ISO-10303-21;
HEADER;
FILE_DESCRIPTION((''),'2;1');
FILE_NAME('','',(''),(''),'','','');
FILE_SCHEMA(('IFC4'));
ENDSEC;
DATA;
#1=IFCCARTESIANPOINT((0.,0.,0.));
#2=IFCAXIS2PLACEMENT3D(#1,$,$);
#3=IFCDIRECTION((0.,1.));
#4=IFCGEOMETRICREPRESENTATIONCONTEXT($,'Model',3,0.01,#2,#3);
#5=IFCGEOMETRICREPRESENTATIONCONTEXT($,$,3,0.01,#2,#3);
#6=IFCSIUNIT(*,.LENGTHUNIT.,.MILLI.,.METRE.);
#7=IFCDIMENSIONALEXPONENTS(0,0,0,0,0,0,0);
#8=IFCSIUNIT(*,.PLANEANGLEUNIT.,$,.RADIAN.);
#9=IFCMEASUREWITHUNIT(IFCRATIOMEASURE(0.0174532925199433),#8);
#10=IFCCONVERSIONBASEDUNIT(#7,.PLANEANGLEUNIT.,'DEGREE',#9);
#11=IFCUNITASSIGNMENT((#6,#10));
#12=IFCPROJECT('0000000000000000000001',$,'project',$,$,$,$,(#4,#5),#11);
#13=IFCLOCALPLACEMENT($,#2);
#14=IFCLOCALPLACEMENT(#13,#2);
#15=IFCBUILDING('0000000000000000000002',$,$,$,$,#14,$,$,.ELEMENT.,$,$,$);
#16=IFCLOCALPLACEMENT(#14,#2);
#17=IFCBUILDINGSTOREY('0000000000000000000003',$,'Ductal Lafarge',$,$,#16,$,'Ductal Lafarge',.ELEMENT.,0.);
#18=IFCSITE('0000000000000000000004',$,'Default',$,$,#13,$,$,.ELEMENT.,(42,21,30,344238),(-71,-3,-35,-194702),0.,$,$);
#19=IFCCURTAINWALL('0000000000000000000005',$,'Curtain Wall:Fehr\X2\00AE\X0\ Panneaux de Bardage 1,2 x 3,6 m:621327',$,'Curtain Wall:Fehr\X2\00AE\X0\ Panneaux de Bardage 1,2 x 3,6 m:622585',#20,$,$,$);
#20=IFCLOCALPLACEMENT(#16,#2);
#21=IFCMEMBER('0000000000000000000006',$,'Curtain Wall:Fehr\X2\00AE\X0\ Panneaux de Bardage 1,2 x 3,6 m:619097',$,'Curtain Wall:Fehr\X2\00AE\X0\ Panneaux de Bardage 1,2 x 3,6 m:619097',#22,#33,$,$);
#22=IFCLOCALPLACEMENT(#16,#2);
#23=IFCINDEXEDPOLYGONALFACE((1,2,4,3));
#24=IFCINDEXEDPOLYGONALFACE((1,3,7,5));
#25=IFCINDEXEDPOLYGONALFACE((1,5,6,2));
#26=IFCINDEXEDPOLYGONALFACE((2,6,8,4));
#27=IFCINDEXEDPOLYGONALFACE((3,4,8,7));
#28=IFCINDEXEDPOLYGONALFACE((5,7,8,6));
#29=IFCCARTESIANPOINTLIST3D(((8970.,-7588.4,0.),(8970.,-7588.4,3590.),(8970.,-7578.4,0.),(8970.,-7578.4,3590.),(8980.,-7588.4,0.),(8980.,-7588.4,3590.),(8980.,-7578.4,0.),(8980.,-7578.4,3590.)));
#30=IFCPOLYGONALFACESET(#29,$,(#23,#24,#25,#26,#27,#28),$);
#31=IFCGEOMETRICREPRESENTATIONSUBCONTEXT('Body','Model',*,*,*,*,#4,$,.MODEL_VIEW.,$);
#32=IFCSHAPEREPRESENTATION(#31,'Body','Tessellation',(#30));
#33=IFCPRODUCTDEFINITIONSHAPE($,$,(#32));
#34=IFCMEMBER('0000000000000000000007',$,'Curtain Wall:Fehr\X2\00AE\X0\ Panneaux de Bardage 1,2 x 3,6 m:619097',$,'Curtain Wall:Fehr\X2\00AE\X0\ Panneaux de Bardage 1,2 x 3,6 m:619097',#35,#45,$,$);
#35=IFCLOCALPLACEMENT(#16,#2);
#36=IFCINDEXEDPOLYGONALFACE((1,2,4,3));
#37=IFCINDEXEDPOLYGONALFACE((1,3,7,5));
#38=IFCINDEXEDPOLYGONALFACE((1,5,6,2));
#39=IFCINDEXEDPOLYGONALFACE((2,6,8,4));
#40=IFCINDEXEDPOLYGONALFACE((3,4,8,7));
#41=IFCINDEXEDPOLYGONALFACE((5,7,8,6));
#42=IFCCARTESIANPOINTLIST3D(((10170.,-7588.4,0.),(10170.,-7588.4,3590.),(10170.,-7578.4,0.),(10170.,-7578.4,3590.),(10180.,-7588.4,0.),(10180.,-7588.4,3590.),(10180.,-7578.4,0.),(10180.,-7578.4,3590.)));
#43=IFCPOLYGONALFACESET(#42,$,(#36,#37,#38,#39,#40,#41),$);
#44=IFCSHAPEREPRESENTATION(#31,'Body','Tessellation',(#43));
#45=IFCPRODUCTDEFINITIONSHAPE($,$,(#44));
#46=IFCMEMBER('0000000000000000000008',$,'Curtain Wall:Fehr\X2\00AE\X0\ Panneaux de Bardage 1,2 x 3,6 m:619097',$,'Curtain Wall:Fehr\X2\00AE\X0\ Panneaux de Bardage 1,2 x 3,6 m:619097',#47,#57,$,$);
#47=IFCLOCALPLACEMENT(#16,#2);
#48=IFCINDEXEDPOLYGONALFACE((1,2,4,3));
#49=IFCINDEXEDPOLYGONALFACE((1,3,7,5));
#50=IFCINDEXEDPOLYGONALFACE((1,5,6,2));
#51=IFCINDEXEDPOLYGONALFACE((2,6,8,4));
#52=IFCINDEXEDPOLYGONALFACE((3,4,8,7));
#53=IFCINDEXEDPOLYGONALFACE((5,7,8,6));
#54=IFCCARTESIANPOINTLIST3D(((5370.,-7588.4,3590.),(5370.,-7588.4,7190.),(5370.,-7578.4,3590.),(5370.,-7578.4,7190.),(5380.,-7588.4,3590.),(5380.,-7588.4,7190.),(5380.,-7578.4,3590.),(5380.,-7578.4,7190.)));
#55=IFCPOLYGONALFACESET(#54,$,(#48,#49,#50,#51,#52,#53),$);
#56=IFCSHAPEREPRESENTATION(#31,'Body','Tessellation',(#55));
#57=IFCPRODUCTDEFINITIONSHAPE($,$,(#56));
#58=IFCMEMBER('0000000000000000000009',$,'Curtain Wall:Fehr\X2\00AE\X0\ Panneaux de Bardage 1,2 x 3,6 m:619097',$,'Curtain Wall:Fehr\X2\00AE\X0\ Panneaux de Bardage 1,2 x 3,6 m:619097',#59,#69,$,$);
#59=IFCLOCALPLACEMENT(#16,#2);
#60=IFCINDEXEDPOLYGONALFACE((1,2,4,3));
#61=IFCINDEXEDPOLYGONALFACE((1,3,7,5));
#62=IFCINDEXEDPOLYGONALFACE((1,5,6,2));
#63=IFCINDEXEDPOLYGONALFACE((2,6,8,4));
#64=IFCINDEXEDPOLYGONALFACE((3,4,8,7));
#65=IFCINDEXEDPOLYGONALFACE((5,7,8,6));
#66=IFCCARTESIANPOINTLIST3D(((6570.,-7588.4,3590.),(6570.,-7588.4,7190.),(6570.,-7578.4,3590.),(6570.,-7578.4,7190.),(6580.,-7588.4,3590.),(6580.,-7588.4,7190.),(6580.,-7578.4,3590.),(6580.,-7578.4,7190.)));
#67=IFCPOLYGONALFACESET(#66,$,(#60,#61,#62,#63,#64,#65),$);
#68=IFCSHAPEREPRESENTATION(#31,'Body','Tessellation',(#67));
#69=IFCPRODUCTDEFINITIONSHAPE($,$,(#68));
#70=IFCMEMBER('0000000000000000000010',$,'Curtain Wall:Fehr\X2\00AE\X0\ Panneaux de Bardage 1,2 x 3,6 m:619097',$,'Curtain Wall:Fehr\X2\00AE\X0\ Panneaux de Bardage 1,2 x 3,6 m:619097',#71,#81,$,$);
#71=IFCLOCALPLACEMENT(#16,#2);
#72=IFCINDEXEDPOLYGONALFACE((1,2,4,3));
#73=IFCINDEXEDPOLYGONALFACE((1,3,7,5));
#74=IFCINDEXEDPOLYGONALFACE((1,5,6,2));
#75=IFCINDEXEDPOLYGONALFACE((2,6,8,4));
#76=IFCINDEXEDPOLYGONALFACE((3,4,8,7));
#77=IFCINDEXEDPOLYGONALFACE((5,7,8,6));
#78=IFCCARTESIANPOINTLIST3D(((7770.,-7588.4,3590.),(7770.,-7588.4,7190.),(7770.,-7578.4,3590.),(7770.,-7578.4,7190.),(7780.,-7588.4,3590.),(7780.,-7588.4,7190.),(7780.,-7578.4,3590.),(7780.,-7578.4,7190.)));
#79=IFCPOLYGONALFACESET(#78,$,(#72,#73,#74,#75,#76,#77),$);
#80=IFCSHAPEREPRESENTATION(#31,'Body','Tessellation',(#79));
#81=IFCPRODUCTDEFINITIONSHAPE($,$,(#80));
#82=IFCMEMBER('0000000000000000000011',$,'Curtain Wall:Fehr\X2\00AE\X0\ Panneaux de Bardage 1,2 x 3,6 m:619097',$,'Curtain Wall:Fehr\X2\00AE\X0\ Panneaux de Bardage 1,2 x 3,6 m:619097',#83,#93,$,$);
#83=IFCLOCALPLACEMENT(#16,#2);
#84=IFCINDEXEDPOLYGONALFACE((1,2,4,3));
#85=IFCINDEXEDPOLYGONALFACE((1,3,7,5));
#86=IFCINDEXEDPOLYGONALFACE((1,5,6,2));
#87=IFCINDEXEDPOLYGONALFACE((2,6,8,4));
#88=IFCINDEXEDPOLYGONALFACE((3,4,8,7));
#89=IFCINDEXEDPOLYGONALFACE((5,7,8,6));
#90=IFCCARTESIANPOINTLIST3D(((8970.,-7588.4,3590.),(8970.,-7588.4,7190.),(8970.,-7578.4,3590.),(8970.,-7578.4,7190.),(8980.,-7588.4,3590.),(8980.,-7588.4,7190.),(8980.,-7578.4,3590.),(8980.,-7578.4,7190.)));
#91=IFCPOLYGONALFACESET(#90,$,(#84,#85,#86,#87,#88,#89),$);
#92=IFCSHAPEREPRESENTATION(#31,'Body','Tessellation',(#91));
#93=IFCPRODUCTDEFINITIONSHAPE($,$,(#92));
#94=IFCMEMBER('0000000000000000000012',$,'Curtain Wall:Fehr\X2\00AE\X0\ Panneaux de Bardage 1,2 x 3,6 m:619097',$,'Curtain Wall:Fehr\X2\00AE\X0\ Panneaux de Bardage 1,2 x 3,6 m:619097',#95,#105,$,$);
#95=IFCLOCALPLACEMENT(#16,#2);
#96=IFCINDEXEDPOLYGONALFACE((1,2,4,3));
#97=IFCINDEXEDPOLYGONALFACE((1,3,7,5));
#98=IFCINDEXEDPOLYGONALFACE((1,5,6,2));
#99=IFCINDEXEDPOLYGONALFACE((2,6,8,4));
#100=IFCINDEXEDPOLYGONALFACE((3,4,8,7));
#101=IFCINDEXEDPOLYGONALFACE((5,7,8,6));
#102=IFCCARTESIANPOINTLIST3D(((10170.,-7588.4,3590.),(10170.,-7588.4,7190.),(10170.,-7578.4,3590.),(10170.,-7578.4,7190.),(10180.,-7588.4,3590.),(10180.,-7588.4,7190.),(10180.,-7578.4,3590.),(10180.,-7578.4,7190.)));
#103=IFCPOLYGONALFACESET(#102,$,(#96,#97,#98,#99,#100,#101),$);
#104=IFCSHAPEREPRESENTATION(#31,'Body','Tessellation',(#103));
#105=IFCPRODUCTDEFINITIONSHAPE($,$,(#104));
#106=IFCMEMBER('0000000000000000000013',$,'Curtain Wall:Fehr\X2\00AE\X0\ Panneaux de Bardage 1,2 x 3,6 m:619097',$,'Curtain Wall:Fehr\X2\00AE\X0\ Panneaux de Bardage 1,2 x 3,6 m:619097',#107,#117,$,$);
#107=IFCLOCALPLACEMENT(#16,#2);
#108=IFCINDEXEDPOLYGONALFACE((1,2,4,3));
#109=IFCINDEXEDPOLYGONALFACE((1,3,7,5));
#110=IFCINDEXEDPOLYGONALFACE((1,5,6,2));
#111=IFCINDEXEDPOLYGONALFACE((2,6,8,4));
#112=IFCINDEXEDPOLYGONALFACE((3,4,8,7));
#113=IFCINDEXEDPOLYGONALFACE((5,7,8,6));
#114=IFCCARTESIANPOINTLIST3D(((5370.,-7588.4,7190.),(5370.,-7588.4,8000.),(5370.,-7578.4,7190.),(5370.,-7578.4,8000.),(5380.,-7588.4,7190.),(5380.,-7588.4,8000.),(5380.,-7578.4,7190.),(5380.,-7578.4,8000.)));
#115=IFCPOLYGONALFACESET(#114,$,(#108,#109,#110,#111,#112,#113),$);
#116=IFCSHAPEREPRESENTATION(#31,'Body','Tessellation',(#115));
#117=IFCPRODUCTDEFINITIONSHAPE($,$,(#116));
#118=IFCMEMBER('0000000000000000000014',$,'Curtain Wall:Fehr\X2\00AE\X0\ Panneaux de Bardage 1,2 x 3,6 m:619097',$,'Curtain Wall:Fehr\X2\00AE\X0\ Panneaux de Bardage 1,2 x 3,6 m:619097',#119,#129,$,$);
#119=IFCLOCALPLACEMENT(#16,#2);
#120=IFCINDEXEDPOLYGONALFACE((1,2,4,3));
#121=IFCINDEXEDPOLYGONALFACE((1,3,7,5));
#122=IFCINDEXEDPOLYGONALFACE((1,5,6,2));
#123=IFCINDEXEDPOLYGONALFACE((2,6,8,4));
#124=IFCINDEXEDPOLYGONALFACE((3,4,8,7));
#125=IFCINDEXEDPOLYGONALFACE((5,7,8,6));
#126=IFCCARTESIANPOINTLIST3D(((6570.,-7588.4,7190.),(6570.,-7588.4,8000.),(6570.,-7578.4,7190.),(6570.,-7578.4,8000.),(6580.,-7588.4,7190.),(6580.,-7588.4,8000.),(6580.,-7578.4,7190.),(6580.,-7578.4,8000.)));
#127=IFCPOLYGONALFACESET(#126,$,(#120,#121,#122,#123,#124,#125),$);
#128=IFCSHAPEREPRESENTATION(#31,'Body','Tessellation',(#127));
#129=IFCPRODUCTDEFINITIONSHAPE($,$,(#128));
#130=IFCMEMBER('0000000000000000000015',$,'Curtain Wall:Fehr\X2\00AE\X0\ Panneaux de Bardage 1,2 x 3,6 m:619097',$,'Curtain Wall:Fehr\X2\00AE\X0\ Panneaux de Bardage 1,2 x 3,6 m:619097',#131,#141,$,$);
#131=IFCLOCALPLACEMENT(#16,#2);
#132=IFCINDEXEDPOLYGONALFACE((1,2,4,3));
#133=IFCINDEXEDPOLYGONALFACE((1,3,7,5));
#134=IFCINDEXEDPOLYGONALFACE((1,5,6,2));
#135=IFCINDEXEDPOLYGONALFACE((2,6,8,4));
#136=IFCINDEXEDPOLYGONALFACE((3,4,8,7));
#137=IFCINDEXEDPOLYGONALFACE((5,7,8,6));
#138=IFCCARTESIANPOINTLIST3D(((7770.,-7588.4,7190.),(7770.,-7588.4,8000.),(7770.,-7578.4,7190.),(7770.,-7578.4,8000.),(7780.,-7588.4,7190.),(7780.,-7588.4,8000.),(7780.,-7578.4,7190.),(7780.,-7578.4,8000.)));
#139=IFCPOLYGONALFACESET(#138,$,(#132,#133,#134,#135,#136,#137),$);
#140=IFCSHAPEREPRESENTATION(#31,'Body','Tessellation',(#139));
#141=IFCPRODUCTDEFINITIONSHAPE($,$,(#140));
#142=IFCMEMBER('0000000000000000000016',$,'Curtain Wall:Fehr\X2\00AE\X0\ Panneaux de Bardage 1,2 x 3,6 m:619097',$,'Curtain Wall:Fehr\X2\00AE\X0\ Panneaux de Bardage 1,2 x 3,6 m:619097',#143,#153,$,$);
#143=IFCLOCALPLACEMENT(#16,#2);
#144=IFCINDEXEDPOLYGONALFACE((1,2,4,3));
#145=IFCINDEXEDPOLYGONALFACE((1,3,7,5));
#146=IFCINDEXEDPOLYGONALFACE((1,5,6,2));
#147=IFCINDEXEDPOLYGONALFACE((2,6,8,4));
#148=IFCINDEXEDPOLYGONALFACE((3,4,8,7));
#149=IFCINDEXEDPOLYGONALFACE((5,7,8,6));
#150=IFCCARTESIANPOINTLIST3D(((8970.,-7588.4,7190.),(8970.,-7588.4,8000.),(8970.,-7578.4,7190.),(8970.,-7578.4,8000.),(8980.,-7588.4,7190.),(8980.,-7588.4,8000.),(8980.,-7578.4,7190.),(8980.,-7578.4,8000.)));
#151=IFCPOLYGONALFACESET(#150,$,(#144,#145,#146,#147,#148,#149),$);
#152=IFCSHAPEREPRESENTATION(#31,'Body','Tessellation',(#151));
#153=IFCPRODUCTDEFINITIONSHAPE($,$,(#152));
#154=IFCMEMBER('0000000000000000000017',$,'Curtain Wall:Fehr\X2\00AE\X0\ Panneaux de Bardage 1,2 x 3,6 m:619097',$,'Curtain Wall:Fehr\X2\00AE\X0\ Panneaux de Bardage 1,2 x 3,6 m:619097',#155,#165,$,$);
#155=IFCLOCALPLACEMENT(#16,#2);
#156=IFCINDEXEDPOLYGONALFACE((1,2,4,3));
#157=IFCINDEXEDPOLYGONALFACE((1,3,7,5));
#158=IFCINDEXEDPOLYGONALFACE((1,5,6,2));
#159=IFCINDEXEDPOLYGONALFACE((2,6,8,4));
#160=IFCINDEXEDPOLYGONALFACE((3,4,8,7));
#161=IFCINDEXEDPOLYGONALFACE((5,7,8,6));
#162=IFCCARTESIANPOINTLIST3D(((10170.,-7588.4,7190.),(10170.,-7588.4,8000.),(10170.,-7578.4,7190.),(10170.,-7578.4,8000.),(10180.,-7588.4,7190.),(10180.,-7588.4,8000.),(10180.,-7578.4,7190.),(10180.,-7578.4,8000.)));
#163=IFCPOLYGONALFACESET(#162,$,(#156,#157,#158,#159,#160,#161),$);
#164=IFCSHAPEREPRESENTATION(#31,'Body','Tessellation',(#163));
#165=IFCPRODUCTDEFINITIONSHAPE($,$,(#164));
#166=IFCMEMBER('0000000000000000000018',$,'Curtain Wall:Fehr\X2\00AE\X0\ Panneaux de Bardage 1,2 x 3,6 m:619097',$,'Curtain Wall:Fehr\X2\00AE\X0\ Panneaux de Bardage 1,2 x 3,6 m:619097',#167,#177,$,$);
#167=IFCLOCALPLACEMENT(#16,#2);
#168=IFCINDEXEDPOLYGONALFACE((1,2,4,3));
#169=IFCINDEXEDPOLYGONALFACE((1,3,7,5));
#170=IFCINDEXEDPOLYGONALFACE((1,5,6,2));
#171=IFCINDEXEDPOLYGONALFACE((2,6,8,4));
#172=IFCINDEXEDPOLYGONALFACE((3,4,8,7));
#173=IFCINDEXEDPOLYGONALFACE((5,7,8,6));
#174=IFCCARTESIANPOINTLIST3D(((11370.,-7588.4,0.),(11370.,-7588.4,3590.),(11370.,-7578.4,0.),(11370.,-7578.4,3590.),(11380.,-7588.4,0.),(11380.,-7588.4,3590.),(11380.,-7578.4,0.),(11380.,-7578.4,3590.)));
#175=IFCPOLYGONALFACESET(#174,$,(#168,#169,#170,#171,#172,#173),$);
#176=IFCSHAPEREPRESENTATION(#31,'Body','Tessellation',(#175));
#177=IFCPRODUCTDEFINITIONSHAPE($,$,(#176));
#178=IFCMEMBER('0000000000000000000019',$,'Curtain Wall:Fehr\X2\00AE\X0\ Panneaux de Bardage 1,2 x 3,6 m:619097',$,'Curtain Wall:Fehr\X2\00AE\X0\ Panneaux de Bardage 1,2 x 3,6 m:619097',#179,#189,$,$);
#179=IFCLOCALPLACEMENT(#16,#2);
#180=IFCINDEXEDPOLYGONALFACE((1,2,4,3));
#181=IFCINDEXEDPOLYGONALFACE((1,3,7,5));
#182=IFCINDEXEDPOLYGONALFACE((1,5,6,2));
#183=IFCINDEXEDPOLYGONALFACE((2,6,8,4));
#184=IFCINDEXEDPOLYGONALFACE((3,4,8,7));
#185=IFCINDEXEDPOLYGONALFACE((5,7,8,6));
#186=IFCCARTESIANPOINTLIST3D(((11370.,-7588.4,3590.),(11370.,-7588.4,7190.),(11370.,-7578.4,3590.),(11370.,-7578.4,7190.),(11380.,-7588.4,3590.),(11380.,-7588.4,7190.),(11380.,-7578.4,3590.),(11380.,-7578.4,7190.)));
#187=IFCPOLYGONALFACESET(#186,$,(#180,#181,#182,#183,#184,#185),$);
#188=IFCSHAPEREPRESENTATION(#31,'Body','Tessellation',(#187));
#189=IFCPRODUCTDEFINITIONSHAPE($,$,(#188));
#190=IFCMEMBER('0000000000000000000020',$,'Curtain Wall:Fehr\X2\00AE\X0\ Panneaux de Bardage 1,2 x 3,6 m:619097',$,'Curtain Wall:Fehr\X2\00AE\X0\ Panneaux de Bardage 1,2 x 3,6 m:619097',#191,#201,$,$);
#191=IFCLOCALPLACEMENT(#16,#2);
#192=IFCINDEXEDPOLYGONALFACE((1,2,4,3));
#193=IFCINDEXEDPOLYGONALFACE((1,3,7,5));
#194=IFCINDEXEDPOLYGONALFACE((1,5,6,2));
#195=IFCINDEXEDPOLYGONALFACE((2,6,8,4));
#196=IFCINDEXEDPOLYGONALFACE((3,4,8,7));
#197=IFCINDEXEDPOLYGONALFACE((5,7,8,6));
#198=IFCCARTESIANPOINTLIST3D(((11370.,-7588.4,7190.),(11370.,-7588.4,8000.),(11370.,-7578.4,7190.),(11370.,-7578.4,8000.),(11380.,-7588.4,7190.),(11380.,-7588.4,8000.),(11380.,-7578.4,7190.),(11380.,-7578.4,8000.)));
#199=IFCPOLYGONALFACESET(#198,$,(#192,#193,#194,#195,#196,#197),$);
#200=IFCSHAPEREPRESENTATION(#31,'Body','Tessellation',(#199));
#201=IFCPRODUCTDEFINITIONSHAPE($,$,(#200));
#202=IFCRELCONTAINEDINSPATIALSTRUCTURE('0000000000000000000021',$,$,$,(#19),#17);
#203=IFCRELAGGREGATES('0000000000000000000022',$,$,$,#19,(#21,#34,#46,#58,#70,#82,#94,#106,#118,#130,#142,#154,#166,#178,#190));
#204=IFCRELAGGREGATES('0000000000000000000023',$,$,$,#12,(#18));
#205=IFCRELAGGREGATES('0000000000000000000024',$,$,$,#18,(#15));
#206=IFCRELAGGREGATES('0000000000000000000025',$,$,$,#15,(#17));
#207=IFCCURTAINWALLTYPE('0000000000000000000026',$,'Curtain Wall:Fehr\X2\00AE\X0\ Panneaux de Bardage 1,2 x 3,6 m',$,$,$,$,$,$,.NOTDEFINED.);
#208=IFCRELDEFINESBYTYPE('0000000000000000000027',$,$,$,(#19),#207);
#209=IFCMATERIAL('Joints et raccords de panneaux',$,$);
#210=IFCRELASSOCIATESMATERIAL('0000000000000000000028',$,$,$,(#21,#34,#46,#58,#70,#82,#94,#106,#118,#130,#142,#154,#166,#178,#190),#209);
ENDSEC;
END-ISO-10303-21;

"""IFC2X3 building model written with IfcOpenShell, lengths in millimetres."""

from ifc_helpers import new_model, entity, si_unit, converted_unit, direction, frame, frame_2d, origin, place, context, subcontext, project, spatial, rectangle, extrude, material, type_object, element, aggregate, save


model = new_model("IFC2X3")

# Units and contexts
model_context = context("Model", 3, precision=0.01, world=origin(), true_north=direction((0.0, 1.0)))
context_of_model = context(None, 3, precision=0.01, world=origin(), true_north=direction((0.0, 1.0)))
body_context = subcontext(model_context, "Body", "Model", "MODEL_VIEW")
ifc_project = project(units=[si_unit("LENGTHUNIT", "METRE", prefix="MILLI"), converted_unit("PLANEANGLEUNIT", "DEGREE", entity("IfcRatioMeasure", 0.0174532925199433), si_unit("PLANEANGLEUNIT", "RADIAN"), dimensions=[0, 0, 0, 0, 0, 0, 0])], contexts=[model_context, context_of_model])

# Site, building, storey
site_placement = place(None, origin())
site = spatial("IfcSite", under=ifc_project, at=site_placement, Name="Default", CompositionType="ELEMENT", RefLatitude=(42, 21, 30, 344238), RefLongitude=(-71, -3, -35, -194702), RefElevation=0.0)
building_placement = place(site_placement, origin())
building = spatial("IfcBuilding", under=site, at=building_placement, CompositionType="ELEMENT")
storey_placement = place(building_placement, origin())
storey = spatial("IfcBuildingStorey", under=building, at=storey_placement, Name="Ductal Lafarge", LongName="Ductal Lafarge", CompositionType="ELEMENT", Elevation=0.0)

# Curtain wall, members
curtain_wall_type = type_object("IfcCurtainWallType", Name="Curtain Wall:Fehr® Panneaux de Bardage 1,2 x 3,6 m", PredefinedType="NOTDEFINED")
curtain_wall_placement = place(storey_placement, origin())
curtain_wall = element("IfcCurtainWall", 1, at=curtain_wall_placement, inside=storey, type_object=curtain_wall_type, Name="Curtain Wall:Fehr® Panneaux de Bardage 1,2 x 3,6 m:621327", ObjectType="Curtain Wall:Fehr® Panneaux de Bardage 1,2 x 3,6 m:622585")
ifc_material = material(Name="Joints et raccords de panneaux")
member_1_placement = place(curtain_wall_placement, frame((8970.0, -7588.4, 0.0)))
member_1 = element("IfcMember", 2, at=member_1_placement, material=ifc_material, Name="Curtain Wall:Fehr® Panneaux de Bardage 1,2 x 3,6 m:619097", ObjectType="Curtain Wall:Fehr® Panneaux de Bardage 1,2 x 3,6 m:619097", context=body_context, shape_type="SweptSolid", body=[
    extrude(rectangle(XDim=10.0, YDim=10.0, at=frame_2d((0.0, 0.0), x_axis=(1.0, 0.0))), frame((5.0, 5.0, 0.0), z_axis=(0.0, 0.0, 1.0), x_axis=(0.0, 1.0, 0.0)), (0.0, 0.0, 1.0), 3590.0),
])
member_2_placement = place(curtain_wall_placement, frame((10170.0, -7588.4, 0.0)))
member_2 = element("IfcMember", 3, at=member_2_placement, material=ifc_material, Name="Curtain Wall:Fehr® Panneaux de Bardage 1,2 x 3,6 m:619097", ObjectType="Curtain Wall:Fehr® Panneaux de Bardage 1,2 x 3,6 m:619097", context=body_context, shape_type="SweptSolid", body=[
    extrude(rectangle(XDim=10.0, YDim=10.0, at=frame_2d((0.0, 0.0), x_axis=(1.0, 0.0))), frame((5.0, 5.0, 0.0), z_axis=(0.0, 0.0, 1.0), x_axis=(0.0, 1.0, 0.0)), (0.0, 0.0, 1.0), 3590.0),
])
member_3_placement = place(curtain_wall_placement, frame((5370.0, -7588.4, 3590.0)))
member_3 = element("IfcMember", 4, at=member_3_placement, material=ifc_material, Name="Curtain Wall:Fehr® Panneaux de Bardage 1,2 x 3,6 m:619097", ObjectType="Curtain Wall:Fehr® Panneaux de Bardage 1,2 x 3,6 m:619097", context=body_context, shape_type="SweptSolid", body=[
    extrude(rectangle(XDim=10.0, YDim=10.0, at=frame_2d((0.0, 0.0), x_axis=(1.0, 0.0))), frame((5.0, 5.0, 0.0), z_axis=(0.0, 0.0, 1.0), x_axis=(0.0, 1.0, 0.0)), (0.0, 0.0, 1.0), 3600.0),
])
member_4_placement = place(curtain_wall_placement, frame((6570.0, -7588.4, 3590.0)))
member_4 = element("IfcMember", 5, at=member_4_placement, material=ifc_material, Name="Curtain Wall:Fehr® Panneaux de Bardage 1,2 x 3,6 m:619097", ObjectType="Curtain Wall:Fehr® Panneaux de Bardage 1,2 x 3,6 m:619097", context=body_context, shape_type="SweptSolid", body=[
    extrude(rectangle(XDim=10.0, YDim=10.0, at=frame_2d((0.0, 0.0), x_axis=(1.0, 0.0))), frame((5.0, 5.0, 0.0), z_axis=(0.0, 0.0, 1.0), x_axis=(0.0, 1.0, 0.0)), (0.0, 0.0, 1.0), 3600.0),
])
member_5_placement = place(curtain_wall_placement, frame((7770.0, -7588.4, 3590.0)))
member_5 = element("IfcMember", 6, at=member_5_placement, material=ifc_material, Name="Curtain Wall:Fehr® Panneaux de Bardage 1,2 x 3,6 m:619097", ObjectType="Curtain Wall:Fehr® Panneaux de Bardage 1,2 x 3,6 m:619097", context=body_context, shape_type="SweptSolid", body=[
    extrude(rectangle(XDim=10.0, YDim=10.0, at=frame_2d((0.0, 0.0), x_axis=(1.0, 0.0))), frame((5.0, 5.0, 0.0), z_axis=(0.0, 0.0, 1.0), x_axis=(0.0, 1.0, 0.0)), (0.0, 0.0, 1.0), 3600.0),
])
member_6_placement = place(curtain_wall_placement, frame((8970.0, -7588.4, 3590.0)))
member_6 = element("IfcMember", 7, at=member_6_placement, material=ifc_material, Name="Curtain Wall:Fehr® Panneaux de Bardage 1,2 x 3,6 m:619097", ObjectType="Curtain Wall:Fehr® Panneaux de Bardage 1,2 x 3,6 m:619097", context=body_context, shape_type="SweptSolid", body=[
    extrude(rectangle(XDim=10.0, YDim=10.0, at=frame_2d((0.0, 0.0), x_axis=(1.0, 0.0))), frame((5.0, 5.0, 0.0), z_axis=(0.0, 0.0, 1.0), x_axis=(0.0, 1.0, 0.0)), (0.0, 0.0, 1.0), 3600.0),
])
member_7_placement = place(curtain_wall_placement, frame((10170.0, -7588.4, 3590.0)))
member_7 = element("IfcMember", 8, at=member_7_placement, material=ifc_material, Name="Curtain Wall:Fehr® Panneaux de Bardage 1,2 x 3,6 m:619097", ObjectType="Curtain Wall:Fehr® Panneaux de Bardage 1,2 x 3,6 m:619097", context=body_context, shape_type="SweptSolid", body=[
    extrude(rectangle(XDim=10.0, YDim=10.0, at=frame_2d((0.0, 0.0), x_axis=(1.0, 0.0))), frame((5.0, 5.0, 0.0), z_axis=(0.0, 0.0, 1.0), x_axis=(0.0, 1.0, 0.0)), (0.0, 0.0, 1.0), 3600.0),
])
member_8_placement = place(curtain_wall_placement, frame((5370.0, -7588.4, 7190.0)))
member_8 = element("IfcMember", 9, at=member_8_placement, material=ifc_material, Name="Curtain Wall:Fehr® Panneaux de Bardage 1,2 x 3,6 m:619097", ObjectType="Curtain Wall:Fehr® Panneaux de Bardage 1,2 x 3,6 m:619097", context=body_context, shape_type="SweptSolid", body=[
    extrude(rectangle(XDim=10.0, YDim=10.0, at=frame_2d((0.0, 0.0), x_axis=(1.0, 0.0))), frame((5.0, 5.0, 0.0), z_axis=(0.0, 0.0, 1.0), x_axis=(0.0, 1.0, 0.0)), (0.0, 0.0, 1.0), 810.0),
])
member_9_placement = place(curtain_wall_placement, frame((6570.0, -7588.4, 7190.0)))
member_9 = element("IfcMember", 10, at=member_9_placement, material=ifc_material, Name="Curtain Wall:Fehr® Panneaux de Bardage 1,2 x 3,6 m:619097", ObjectType="Curtain Wall:Fehr® Panneaux de Bardage 1,2 x 3,6 m:619097", context=body_context, shape_type="SweptSolid", body=[
    extrude(rectangle(XDim=10.0, YDim=10.0, at=frame_2d((0.0, 0.0), x_axis=(1.0, 0.0))), frame((5.0, 5.0, 0.0), z_axis=(0.0, 0.0, 1.0), x_axis=(0.0, 1.0, 0.0)), (0.0, 0.0, 1.0), 810.0),
])
member_10_placement = place(curtain_wall_placement, frame((7770.0, -7588.4, 7190.0)))
member_10 = element("IfcMember", 11, at=member_10_placement, material=ifc_material, Name="Curtain Wall:Fehr® Panneaux de Bardage 1,2 x 3,6 m:619097", ObjectType="Curtain Wall:Fehr® Panneaux de Bardage 1,2 x 3,6 m:619097", context=body_context, shape_type="SweptSolid", body=[
    extrude(rectangle(XDim=10.0, YDim=10.0, at=frame_2d((0.0, 0.0), x_axis=(1.0, 0.0))), frame((5.0, 5.0, 0.0), z_axis=(0.0, 0.0, 1.0), x_axis=(0.0, 1.0, 0.0)), (0.0, 0.0, 1.0), 810.0),
])
member_11_placement = place(curtain_wall_placement, frame((8970.0, -7588.4, 7190.0)))
member_11 = element("IfcMember", 12, at=member_11_placement, material=ifc_material, Name="Curtain Wall:Fehr® Panneaux de Bardage 1,2 x 3,6 m:619097", ObjectType="Curtain Wall:Fehr® Panneaux de Bardage 1,2 x 3,6 m:619097", context=body_context, shape_type="SweptSolid", body=[
    extrude(rectangle(XDim=10.0, YDim=10.0, at=frame_2d((0.0, 0.0), x_axis=(1.0, 0.0))), frame((5.0, 5.0, 0.0), z_axis=(0.0, 0.0, 1.0), x_axis=(0.0, 1.0, 0.0)), (0.0, 0.0, 1.0), 810.0),
])
member_12_placement = place(curtain_wall_placement, frame((10170.0, -7588.4, 7190.0)))
member_12 = element("IfcMember", 13, at=member_12_placement, material=ifc_material, Name="Curtain Wall:Fehr® Panneaux de Bardage 1,2 x 3,6 m:619097", ObjectType="Curtain Wall:Fehr® Panneaux de Bardage 1,2 x 3,6 m:619097", context=body_context, shape_type="SweptSolid", body=[
    extrude(rectangle(XDim=10.0, YDim=10.0, at=frame_2d((0.0, 0.0), x_axis=(1.0, 0.0))), frame((5.0, 5.0, 0.0), z_axis=(0.0, 0.0, 1.0), x_axis=(0.0, 1.0, 0.0)), (0.0, 0.0, 1.0), 810.0),
])
member_13_placement = place(curtain_wall_placement, frame((11370.0, -7588.4, 0.0)))
member_13 = element("IfcMember", 14, at=member_13_placement, material=ifc_material, Name="Curtain Wall:Fehr® Panneaux de Bardage 1,2 x 3,6 m:619097", ObjectType="Curtain Wall:Fehr® Panneaux de Bardage 1,2 x 3,6 m:619097", context=body_context, shape_type="SweptSolid", body=[
    extrude(rectangle(XDim=10.0, YDim=10.0, at=frame_2d((0.0, 0.0), x_axis=(1.0, 0.0))), frame((5.0, 5.0, 0.0), z_axis=(0.0, 0.0, 1.0), x_axis=(0.0, 1.0, 0.0)), (0.0, 0.0, 1.0), 3590.0),
])
member_14_placement = place(curtain_wall_placement, frame((11370.0, -7588.4, 3590.0)))
member_14 = element("IfcMember", 15, at=member_14_placement, material=ifc_material, Name="Curtain Wall:Fehr® Panneaux de Bardage 1,2 x 3,6 m:619097", ObjectType="Curtain Wall:Fehr® Panneaux de Bardage 1,2 x 3,6 m:619097", context=body_context, shape_type="SweptSolid", body=[
    extrude(rectangle(XDim=10.0, YDim=10.0, at=frame_2d((0.0, 0.0), x_axis=(1.0, 0.0))), frame((5.0, 5.0, 0.0), z_axis=(0.0, 0.0, 1.0), x_axis=(0.0, 1.0, 0.0)), (0.0, 0.0, 1.0), 3600.0),
])
member_15_placement = place(curtain_wall_placement, frame((11370.0, -7588.4, 7190.0)))
member_15 = element("IfcMember", 16, at=member_15_placement, material=ifc_material, Name="Curtain Wall:Fehr® Panneaux de Bardage 1,2 x 3,6 m:619097", ObjectType="Curtain Wall:Fehr® Panneaux de Bardage 1,2 x 3,6 m:619097", context=body_context, shape_type="SweptSolid", body=[
    extrude(rectangle(XDim=10.0, YDim=10.0, at=frame_2d((0.0, 0.0), x_axis=(1.0, 0.0))), frame((5.0, 5.0, 0.0), z_axis=(0.0, 0.0, 1.0), x_axis=(0.0, 1.0, 0.0)), (0.0, 0.0, 1.0), 810.0),
])
aggregate(curtain_wall, [member_1, member_2, member_3, member_4, member_5, member_6, member_7, member_8, member_9, member_10, member_11, member_12, member_13, member_14, member_15])

save(model, "model.ifc")
